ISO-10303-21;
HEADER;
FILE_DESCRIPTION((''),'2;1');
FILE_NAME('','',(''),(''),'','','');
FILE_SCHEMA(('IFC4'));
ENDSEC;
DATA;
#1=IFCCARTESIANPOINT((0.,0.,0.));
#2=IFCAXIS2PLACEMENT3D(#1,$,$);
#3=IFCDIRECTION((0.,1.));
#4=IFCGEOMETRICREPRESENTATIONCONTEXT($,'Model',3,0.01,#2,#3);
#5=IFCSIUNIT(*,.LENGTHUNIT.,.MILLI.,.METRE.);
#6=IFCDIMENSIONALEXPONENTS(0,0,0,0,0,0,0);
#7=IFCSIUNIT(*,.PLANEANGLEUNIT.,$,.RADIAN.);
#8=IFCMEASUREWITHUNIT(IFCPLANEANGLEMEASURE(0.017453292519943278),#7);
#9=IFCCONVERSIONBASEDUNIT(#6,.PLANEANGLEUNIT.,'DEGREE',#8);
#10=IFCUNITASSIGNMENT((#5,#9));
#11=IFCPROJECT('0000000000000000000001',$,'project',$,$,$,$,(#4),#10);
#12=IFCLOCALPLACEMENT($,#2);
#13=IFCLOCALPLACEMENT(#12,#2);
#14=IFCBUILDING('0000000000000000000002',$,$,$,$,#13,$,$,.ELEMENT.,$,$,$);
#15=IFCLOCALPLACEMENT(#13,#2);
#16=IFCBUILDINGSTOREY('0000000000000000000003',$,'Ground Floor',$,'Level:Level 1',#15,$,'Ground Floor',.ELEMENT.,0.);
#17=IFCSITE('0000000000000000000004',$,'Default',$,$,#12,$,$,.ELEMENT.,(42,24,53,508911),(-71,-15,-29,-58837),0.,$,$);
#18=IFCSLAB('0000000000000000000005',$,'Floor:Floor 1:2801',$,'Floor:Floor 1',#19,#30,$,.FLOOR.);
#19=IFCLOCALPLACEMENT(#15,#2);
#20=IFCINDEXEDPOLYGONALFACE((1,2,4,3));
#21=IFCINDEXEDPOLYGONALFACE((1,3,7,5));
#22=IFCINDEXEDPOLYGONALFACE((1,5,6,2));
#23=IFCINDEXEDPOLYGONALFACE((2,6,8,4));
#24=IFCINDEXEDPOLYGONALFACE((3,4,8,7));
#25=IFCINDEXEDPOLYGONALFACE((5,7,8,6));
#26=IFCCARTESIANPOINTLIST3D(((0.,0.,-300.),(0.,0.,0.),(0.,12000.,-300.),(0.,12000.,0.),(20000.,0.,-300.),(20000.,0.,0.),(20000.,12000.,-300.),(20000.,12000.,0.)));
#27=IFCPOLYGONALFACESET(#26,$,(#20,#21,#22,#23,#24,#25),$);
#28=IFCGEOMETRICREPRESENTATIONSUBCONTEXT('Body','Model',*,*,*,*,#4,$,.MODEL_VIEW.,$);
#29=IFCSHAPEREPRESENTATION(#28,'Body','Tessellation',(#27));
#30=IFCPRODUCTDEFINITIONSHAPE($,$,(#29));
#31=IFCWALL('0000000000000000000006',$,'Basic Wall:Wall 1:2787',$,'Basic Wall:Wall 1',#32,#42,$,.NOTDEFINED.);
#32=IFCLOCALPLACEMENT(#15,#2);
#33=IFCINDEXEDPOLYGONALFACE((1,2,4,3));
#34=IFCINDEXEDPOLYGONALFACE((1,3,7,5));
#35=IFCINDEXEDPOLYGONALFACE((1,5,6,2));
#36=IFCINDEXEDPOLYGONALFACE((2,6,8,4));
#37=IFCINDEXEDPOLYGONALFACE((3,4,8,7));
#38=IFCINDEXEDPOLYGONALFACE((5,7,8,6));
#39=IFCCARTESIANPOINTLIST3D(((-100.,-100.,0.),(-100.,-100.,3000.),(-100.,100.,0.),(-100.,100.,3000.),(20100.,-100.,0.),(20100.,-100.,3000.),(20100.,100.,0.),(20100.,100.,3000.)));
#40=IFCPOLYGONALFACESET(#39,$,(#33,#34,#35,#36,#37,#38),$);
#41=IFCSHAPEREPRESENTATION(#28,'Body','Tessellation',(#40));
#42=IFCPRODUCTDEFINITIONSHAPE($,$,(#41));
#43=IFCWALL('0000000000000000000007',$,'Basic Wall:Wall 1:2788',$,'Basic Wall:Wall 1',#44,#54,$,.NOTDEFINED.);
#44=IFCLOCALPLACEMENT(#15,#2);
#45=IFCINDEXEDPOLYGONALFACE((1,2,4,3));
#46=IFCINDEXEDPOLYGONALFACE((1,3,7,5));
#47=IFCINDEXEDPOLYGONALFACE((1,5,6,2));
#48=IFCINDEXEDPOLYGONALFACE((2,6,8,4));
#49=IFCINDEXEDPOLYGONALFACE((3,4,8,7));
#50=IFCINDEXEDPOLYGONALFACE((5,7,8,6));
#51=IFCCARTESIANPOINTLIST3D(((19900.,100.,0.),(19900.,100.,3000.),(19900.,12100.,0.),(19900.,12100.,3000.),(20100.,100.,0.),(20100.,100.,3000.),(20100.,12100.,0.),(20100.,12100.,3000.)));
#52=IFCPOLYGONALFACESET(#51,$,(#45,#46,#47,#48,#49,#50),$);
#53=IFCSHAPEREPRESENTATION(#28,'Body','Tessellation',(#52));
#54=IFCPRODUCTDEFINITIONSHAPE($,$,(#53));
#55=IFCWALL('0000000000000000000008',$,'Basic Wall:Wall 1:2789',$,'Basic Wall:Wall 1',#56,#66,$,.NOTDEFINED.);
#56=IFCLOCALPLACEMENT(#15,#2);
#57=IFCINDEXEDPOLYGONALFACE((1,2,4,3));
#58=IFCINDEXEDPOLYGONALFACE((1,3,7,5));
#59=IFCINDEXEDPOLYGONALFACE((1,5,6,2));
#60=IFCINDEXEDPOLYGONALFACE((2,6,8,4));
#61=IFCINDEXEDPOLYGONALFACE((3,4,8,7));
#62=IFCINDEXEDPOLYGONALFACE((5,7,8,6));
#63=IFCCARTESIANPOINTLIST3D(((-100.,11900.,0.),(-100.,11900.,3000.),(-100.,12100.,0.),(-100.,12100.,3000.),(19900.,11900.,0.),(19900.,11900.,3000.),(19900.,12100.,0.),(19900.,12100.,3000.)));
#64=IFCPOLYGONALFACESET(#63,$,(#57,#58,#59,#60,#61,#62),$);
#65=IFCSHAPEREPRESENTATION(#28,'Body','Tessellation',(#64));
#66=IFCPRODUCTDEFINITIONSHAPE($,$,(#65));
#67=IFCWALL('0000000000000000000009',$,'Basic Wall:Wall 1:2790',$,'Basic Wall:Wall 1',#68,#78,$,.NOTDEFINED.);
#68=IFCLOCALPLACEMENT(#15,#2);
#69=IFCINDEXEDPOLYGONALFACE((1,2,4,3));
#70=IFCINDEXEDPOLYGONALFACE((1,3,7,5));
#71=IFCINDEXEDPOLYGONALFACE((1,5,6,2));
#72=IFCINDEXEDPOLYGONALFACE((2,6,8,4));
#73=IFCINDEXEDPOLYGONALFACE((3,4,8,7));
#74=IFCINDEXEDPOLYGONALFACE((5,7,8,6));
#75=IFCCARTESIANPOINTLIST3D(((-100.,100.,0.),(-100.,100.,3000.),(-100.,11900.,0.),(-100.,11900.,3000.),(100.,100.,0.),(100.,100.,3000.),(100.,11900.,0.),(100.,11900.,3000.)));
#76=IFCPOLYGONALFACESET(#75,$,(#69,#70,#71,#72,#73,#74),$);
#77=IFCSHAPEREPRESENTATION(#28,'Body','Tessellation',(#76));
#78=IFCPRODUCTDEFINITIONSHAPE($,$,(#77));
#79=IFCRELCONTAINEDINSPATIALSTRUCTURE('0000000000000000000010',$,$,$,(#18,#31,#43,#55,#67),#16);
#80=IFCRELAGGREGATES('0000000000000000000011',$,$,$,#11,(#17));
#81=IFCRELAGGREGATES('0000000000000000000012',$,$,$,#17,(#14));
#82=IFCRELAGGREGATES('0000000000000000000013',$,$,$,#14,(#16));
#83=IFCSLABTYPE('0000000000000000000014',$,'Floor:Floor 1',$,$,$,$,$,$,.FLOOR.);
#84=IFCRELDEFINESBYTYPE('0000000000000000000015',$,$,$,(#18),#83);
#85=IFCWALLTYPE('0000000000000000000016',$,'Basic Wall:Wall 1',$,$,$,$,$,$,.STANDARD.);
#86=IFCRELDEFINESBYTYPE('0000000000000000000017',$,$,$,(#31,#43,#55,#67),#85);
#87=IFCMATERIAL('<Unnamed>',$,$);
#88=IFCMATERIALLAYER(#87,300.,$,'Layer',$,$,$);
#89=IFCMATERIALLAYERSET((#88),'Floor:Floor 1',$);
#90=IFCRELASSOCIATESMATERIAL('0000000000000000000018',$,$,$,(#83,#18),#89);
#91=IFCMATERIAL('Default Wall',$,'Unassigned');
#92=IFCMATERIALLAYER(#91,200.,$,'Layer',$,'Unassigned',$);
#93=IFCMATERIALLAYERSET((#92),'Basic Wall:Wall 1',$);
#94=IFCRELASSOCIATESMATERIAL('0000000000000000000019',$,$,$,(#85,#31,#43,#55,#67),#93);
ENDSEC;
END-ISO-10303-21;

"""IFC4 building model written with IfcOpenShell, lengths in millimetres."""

from ifc_helpers import new_model, entity, si_unit, converted_unit, direction, frame, frame_2d, origin, origin_2d_with_axis, place, context, subcontext, project, spatial, rectangle, extrude, material, layer, layer_set, layer_usage, type_object, element, save


model = new_model("IFC4")

# Units and contexts
model_context = context("Model", 3, precision=0.01, world=origin(), true_north=direction((0.0, 1.0)))
body_context = subcontext(model_context, "Body", "Model", "MODEL_VIEW")
ifc_project = project(units=[si_unit("LENGTHUNIT", "METRE", prefix="MILLI"), converted_unit("PLANEANGLEUNIT", "DEGREE", entity("IfcPlaneAngleMeasure", 0.017453292519943278), si_unit("PLANEANGLEUNIT", "RADIAN"), dimensions=[0, 0, 0, 0, 0, 0, 0])], contexts=[model_context])

# Site, building, storey
site_placement = place(None, origin())
site = spatial("IfcSite", under=ifc_project, at=site_placement, Name="Default", CompositionType="ELEMENT", RefLatitude=(42, 24, 53, 508911), RefLongitude=(-71, -15, -29, -58837), RefElevation=0.0)
building_placement = place(site_placement, origin())
building = spatial("IfcBuilding", under=site, at=building_placement, CompositionType="ELEMENT")
storey_placement = place(building_placement, origin())
storey = spatial("IfcBuildingStorey", under=building, at=storey_placement, Name="Ground Floor", ObjectType="Level:Level 1", LongName="Ground Floor", CompositionType="ELEMENT", Elevation=0.0)

# Shared definitions
ifc_material_1 = material(Name="Default Wall", Category="Unassigned")

# Slab
ifc_material_2 = material(Name="<Unnamed>")
ifc_layer_1 = layer(ifc_material_2, 300.0, Name="Layer")
ifc_layer_set_1 = layer_set([ifc_layer_1], Name="Floor:Floor 1")
ifc_layer_usage_1 = layer_usage(ifc_layer_set_1, "AXIS3", "POSITIVE", 0.0)
slab_type = type_object("IfcSlabType", Name="Floor:Floor 1", PredefinedType="FLOOR", material=ifc_layer_set_1)
slab_placement = place(storey_placement, origin())
element("IfcSlab", 1, at=slab_placement, inside=storey, type_object=slab_type, material=ifc_layer_usage_1, Name="Floor:Floor 1:2801", ObjectType="Floor:Floor 1", PredefinedType="FLOOR", context=body_context, shape_type="SweptSolid", body=[
    extrude(rectangle(XDim=12000.0, YDim=20000.0, at=origin_2d_with_axis()), frame((10000.0, 6000.0, 0.0), z_axis=(0.0, 0.0, -1.0), x_axis=(0.0, 1.0, 0.0)), (0.0, 0.0, 1.0), 300.0),
])

# Walls
ifc_layer_2 = layer(ifc_material_1, 200.0, Name="Layer", Category="Unassigned")
ifc_layer_set_2 = layer_set([ifc_layer_2], Name="Basic Wall:Wall 1")
ifc_layer_usage_2 = layer_usage(ifc_layer_set_2, "AXIS2", "NEGATIVE", 100.0)
wall_type = type_object("IfcWallType", Name="Basic Wall:Wall 1", PredefinedType="STANDARD", material=ifc_layer_set_2)
wall_1_placement = place(storey_placement, frame((-100.0, 0.0, 0.0)))
element("IfcWall", 2, at=wall_1_placement, inside=storey, type_object=wall_type, material=ifc_layer_usage_2, Name="Basic Wall:Wall 1:2787", ObjectType="Basic Wall:Wall 1", PredefinedType="NOTDEFINED", context=body_context, shape_type="SweptSolid", body=[
    extrude(rectangle(XDim=20200.0, YDim=200.0, at=frame_2d((10100.0, 0.0), x_axis=(-1.0, 0.0))), origin(), (0.0, 0.0, 1.0), 3000.0),
])
ifc_layer_usage_3 = layer_usage(ifc_layer_set_2, "AXIS2", "NEGATIVE", 100.0)
wall_2_placement = place(storey_placement, frame((20000.0, 100.0, 0.0), z_axis=(0.0, 0.0, 1.0), x_axis=(0.0, 1.0, 0.0)))
element("IfcWall", 3, at=wall_2_placement, inside=storey, type_object=wall_type, material=ifc_layer_usage_3, Name="Basic Wall:Wall 1:2788", ObjectType="Basic Wall:Wall 1", PredefinedType="NOTDEFINED", context=body_context, shape_type="SweptSolid", body=[
    extrude(rectangle(XDim=12000.0, YDim=200.0, at=frame_2d((6000.0, 0.0), x_axis=(-1.0, 0.0))), origin(), (0.0, 0.0, 1.0), 3000.0),
])
ifc_layer_usage_4 = layer_usage(ifc_layer_set_2, "AXIS2", "NEGATIVE", 100.0)
wall_3_placement = place(storey_placement, frame((19900.0, 12000.0, 0.0), z_axis=(0.0, 0.0, 1.0), x_axis=(-1.0, 0.0, 0.0)))
element("IfcWall", 4, at=wall_3_placement, inside=storey, type_object=wall_type, material=ifc_layer_usage_4, Name="Basic Wall:Wall 1:2789", ObjectType="Basic Wall:Wall 1", PredefinedType="NOTDEFINED", context=body_context, shape_type="SweptSolid", body=[
    extrude(rectangle(XDim=20000.0, YDim=200.0, at=frame_2d((10000.0, 0.0), x_axis=(-1.0, 0.0))), origin(), (0.0, 0.0, 1.0), 3000.0),
])
ifc_layer_usage_5 = layer_usage(ifc_layer_set_2, "AXIS2", "NEGATIVE", 100.0)
wall_4_placement = place(storey_placement, frame((0.0, 11900.0, 0.0), z_axis=(0.0, 0.0, 1.0), x_axis=(0.0, -1.0, 0.0)))
element("IfcWall", 5, at=wall_4_placement, inside=storey, type_object=wall_type, material=ifc_layer_usage_5, Name="Basic Wall:Wall 1:2790", ObjectType="Basic Wall:Wall 1", PredefinedType="NOTDEFINED", context=body_context, shape_type="SweptSolid", body=[
    extrude(rectangle(XDim=11800.0, YDim=200.0, at=frame_2d((5900.0, 0.0), x_axis=(-1.0, 0.0))), origin(), (0.0, 0.0, 1.0), 3000.0),
])

save(model, "model.ifc")
